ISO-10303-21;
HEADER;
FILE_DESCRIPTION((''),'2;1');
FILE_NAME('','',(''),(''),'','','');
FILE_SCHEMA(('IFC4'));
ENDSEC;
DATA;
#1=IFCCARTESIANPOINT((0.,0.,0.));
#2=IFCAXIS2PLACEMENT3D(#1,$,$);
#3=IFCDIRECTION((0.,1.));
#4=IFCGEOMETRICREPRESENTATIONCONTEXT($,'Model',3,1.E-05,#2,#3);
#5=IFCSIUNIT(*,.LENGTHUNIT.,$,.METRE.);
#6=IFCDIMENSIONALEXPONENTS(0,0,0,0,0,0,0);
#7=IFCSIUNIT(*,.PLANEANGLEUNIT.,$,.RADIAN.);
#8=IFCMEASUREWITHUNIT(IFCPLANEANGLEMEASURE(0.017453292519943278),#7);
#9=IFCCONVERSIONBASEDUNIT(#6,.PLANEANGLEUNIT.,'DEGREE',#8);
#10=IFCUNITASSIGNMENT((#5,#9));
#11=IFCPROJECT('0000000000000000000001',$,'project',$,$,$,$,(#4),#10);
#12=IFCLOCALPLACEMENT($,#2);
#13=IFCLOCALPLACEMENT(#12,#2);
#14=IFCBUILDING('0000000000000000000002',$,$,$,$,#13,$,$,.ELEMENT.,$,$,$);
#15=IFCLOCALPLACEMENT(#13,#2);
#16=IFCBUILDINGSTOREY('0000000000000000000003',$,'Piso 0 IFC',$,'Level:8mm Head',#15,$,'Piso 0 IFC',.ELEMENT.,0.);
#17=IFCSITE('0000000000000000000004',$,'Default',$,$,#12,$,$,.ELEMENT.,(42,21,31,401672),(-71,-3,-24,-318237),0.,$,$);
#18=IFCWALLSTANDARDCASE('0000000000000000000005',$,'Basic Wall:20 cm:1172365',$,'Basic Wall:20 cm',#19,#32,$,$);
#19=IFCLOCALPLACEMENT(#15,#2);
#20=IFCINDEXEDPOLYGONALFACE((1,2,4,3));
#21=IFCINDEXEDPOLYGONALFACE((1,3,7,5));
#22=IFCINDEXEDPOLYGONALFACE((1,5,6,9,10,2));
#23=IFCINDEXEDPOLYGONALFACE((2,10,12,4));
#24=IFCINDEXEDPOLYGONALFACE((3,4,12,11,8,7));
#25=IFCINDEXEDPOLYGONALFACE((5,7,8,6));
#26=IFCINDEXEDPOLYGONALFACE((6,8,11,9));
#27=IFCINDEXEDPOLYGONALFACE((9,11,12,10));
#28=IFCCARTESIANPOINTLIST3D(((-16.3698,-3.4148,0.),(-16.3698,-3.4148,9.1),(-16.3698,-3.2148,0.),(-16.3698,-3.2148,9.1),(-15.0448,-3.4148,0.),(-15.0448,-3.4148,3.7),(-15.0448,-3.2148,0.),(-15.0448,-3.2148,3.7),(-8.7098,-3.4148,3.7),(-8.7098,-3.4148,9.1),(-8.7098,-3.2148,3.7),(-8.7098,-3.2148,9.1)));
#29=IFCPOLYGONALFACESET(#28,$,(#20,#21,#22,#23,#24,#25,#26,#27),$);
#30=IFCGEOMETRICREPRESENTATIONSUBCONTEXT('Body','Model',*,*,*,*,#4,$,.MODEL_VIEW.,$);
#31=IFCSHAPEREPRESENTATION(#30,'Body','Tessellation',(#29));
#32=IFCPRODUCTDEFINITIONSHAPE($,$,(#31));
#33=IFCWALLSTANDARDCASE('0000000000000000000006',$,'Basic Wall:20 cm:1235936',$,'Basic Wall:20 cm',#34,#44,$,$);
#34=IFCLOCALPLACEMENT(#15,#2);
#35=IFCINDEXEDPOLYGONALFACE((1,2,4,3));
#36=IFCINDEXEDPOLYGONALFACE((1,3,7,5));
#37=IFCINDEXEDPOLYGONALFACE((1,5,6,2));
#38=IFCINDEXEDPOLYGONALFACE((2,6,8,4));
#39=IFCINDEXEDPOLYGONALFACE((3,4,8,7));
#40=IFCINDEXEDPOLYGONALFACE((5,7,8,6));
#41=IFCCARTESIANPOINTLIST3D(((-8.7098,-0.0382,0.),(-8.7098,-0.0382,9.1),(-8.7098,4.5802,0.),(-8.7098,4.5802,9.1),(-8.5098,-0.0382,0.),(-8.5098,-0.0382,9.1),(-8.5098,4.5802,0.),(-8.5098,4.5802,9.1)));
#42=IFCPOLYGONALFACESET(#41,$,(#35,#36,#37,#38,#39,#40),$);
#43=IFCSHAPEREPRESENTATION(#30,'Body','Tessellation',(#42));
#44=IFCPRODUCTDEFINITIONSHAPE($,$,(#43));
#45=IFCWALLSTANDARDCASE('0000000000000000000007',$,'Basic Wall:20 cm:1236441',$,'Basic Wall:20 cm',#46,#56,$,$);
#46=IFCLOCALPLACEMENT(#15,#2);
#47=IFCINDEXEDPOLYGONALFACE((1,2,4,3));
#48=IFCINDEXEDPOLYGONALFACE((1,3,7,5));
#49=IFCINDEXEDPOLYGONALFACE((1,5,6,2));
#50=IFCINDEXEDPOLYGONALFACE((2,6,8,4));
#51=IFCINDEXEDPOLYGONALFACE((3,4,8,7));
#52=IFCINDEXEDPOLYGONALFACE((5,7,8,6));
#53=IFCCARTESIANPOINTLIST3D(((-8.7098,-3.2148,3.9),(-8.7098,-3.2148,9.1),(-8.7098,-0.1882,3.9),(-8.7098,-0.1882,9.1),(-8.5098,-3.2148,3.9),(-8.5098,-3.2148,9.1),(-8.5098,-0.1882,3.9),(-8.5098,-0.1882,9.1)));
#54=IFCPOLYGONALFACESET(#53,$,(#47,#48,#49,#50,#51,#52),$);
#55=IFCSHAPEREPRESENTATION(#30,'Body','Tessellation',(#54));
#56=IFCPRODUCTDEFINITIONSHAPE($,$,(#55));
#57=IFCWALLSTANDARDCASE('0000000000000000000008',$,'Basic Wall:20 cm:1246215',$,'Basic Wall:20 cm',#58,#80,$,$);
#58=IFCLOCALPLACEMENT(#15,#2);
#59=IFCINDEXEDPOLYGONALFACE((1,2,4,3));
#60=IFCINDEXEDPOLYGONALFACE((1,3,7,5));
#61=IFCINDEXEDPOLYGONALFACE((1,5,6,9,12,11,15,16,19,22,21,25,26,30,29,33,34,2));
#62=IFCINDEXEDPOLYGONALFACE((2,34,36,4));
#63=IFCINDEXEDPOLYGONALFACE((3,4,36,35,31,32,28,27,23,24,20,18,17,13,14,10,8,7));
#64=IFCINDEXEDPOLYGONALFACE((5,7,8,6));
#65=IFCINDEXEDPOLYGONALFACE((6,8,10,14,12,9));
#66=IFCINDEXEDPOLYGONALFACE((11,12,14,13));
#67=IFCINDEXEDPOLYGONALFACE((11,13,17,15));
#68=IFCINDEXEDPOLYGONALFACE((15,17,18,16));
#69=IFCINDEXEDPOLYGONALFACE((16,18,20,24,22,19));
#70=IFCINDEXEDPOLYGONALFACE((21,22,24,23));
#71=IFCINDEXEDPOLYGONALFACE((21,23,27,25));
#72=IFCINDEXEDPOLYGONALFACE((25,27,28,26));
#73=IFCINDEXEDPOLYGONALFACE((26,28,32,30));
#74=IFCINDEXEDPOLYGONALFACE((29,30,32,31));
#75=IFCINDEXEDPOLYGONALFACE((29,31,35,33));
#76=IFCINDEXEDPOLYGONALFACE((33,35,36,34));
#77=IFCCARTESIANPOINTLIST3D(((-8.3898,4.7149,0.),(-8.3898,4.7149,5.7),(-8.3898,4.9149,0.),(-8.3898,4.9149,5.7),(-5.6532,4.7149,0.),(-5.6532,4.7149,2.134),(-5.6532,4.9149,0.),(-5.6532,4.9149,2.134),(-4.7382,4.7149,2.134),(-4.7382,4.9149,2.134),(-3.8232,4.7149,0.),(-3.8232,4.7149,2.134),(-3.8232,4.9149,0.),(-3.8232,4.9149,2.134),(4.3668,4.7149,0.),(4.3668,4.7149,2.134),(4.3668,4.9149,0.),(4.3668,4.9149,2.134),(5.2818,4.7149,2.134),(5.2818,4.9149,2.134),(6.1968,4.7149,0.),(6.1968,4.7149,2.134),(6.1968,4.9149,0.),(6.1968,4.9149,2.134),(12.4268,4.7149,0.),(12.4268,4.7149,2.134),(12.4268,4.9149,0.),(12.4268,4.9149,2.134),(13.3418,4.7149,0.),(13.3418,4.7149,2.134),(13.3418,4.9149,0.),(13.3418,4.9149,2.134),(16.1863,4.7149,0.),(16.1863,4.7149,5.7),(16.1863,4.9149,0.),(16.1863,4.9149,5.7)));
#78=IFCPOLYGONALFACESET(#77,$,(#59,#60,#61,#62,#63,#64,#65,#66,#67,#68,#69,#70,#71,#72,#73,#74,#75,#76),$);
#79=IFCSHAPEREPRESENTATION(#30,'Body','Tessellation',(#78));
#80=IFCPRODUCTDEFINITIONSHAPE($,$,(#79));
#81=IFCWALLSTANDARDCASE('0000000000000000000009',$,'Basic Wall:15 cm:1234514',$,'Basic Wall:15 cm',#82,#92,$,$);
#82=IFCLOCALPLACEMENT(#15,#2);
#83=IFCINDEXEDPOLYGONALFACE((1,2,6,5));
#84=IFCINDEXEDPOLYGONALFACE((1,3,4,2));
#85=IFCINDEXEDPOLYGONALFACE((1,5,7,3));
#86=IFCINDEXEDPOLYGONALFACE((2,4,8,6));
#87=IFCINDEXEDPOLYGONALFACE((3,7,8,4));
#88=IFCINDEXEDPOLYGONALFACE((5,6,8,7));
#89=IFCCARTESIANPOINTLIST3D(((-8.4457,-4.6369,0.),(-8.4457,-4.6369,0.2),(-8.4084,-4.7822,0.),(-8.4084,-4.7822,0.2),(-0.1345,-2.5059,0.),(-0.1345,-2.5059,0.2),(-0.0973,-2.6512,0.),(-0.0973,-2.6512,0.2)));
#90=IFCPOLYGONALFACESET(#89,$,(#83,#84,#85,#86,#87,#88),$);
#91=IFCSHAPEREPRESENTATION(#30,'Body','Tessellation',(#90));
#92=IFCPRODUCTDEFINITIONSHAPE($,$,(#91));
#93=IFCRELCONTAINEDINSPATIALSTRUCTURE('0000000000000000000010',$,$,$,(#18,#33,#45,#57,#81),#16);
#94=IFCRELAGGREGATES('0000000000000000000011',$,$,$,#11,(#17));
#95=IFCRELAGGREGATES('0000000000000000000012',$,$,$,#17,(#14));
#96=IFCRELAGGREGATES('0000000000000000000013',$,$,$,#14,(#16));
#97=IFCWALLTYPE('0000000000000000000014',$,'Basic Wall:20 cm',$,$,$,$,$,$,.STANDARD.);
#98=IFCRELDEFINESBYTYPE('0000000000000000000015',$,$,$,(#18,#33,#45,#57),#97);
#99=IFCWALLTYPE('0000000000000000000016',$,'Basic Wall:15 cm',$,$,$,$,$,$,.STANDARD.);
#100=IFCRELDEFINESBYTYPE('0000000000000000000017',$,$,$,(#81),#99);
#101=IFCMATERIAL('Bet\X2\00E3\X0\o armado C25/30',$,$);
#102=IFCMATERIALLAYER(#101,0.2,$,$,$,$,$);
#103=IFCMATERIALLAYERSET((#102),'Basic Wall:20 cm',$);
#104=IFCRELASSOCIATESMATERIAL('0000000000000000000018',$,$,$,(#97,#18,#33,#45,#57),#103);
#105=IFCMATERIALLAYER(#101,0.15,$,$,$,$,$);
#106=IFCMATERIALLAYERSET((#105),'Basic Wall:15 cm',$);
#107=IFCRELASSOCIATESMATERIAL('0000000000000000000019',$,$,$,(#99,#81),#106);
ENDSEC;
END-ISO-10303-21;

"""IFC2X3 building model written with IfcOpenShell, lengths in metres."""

from ifc_helpers import new_model, entity, si_unit, converted_unit, direction, frame, frame_2d, origin, origin_2d_with_axis, place, context, subcontext, project, spatial, polyline, rectangle, extrude, clip, bounded_halfspace, material, layer, layer_set, layer_usage, type_object, element, save


model = new_model("IFC2X3")

# Units and contexts
model_context = context("Model", 3, precision=1e-05, world=origin(), true_north=direction((0.0, 1.0)))
body_context = subcontext(model_context, "Body", "Model", "MODEL_VIEW")
ifc_project = project(units=[si_unit("LENGTHUNIT", "METRE"), converted_unit("PLANEANGLEUNIT", "DEGREE", entity("IfcPlaneAngleMeasure", 0.017453292519943278), si_unit("PLANEANGLEUNIT", "RADIAN"), dimensions=[0, 0, 0, 0, 0, 0, 0])], contexts=[model_context])

# Site, building, storey
site_placement = place(None, origin())
site = spatial("IfcSite", under=ifc_project, at=site_placement, Name="Default", CompositionType="ELEMENT", RefLatitude=(42, 21, 31, 401672), RefLongitude=(-71, -3, -24, -318237), RefElevation=0.0)
building_placement = place(site_placement, origin())
building = spatial("IfcBuilding", under=site, at=building_placement, CompositionType="ELEMENT")
storey_placement = place(building_placement, origin())
storey = spatial("IfcBuildingStorey", under=building, at=storey_placement, Name="Piso 0 IFC", ObjectType="Level:8mm Head", LongName="Piso 0 IFC", CompositionType="ELEMENT", Elevation=0.0)

# Wall, opening
ifc_material_1 = material(Name="Betão armado C25/30")
ifc_layer_1 = layer(ifc_material_1, 0.2)
ifc_layer_set_1 = layer_set([ifc_layer_1], Name="Basic Wall:20 cm")
ifc_layer_usage_1 = layer_usage(ifc_layer_set_1, "AXIS2", "NEGATIVE", 0.1)
wall_type_1 = type_object("IfcWallType", Name="Basic Wall:20 cm", PredefinedType="STANDARD", material=ifc_layer_set_1)
wall_1_placement = place(storey_placement, frame((-8.7098, -3.3148, 0.0), z_axis=(0.0, 0.0, 1.0), x_axis=(-1.0, 0.0, 0.0)))
wall_1 = element("IfcWallStandardCase", 1, at=wall_1_placement, inside=storey, type_object=wall_type_1, material=ifc_layer_usage_1, Name="Basic Wall:20 cm:1172365", ObjectType="Basic Wall:20 cm", context=body_context, shape_type="Clipping", body=[
    clip(extrude(rectangle(XDim=7.66, YDim=0.2, at=frame_2d((3.83, 0.0), x_axis=(-1.0, 0.0))), origin(), (0.0, 0.0, 1.0), 9.1), bounded_halfspace(frame((0.0, -0.1, 9.1), z_axis=(0.0, 0.0, -1.0), x_axis=(1.0, 0.0, 0.0)), True, frame((0.0, -0.1, 9.1)), polyline([(0.0, 0.0), (7.66, 0.0), (7.66, 0.2), (7.46, 0.2), (0.0, 0.2), (0.0, 0.0)]))),
])
opening_1_placement = place(wall_1_placement, origin())
element("IfcOpeningElement", 2, at=opening_1_placement, cuts=wall_1, ObjectType="Opening", context=body_context, shape_type="SweptSolid", body=[
    extrude(rectangle(XDim=3.7, YDim=6.435, at=origin_2d_with_axis()), frame((3.1175, 0.1, 1.85), z_axis=(0.0, -1.0, 0.0), x_axis=(0.0, 0.0, 1.0)), (0.0, 0.0, 1.0), 0.2),
])

# Walls
ifc_layer_usage_2 = layer_usage(ifc_layer_set_1, "AXIS2", "NEGATIVE", 0.1)
wall_2_placement = place(storey_placement, frame((-8.6098, -0.0382, 0.0), z_axis=(0.0, 0.0, 1.0), x_axis=(0.0, 1.0, 0.0)))
element("IfcWallStandardCase", 3, at=wall_2_placement, inside=storey, type_object=wall_type_1, material=ifc_layer_usage_2, Name="Basic Wall:20 cm:1235936", ObjectType="Basic Wall:20 cm", context=body_context, shape_type="Clipping", body=[
    clip(extrude(rectangle(XDim=4.6184, YDim=0.2, at=frame_2d((2.3092, 0.0), x_axis=(-1.0, 0.0))), origin(), (0.0, 0.0, 1.0), 9.1), bounded_halfspace(frame((0.0, -0.1, 9.1), z_axis=(0.0, 0.0, -1.0), x_axis=(0.0, 1.0, 0.0)), True, frame((0.0, -0.1, 9.1)), polyline([(0.0, 0.0), (4.6184, 0.0), (4.6184, 0.2), (0.0, 0.2), (0.0, 0.0)]))),
])
ifc_layer_usage_3 = layer_usage(ifc_layer_set_1, "AXIS2", "NEGATIVE", 0.1)
wall_3_placement = place(storey_placement, frame((-8.6098, -0.1882, 3.9), z_axis=(0.0, 0.0, 1.0), x_axis=(0.0, -1.0, 0.0)))
element("IfcWallStandardCase", 4, at=wall_3_placement, inside=storey, type_object=wall_type_1, material=ifc_layer_usage_3, Name="Basic Wall:20 cm:1236441", ObjectType="Basic Wall:20 cm", context=body_context, shape_type="Clipping", body=[
    clip(extrude(rectangle(XDim=3.0266, YDim=0.2, at=frame_2d((1.5133, 0.0), x_axis=(-1.0, 0.0))), origin(), (0.0, 0.0, 1.0), 5.2), bounded_halfspace(frame((0.0, -0.1, 5.2), z_axis=(0.0, 0.0, -1.0), x_axis=(0.0, -1.0, 0.0)), True, frame((0.0, -0.1, 5.2)), polyline([(0.0, 0.0), (3.0266, 0.0), (3.0266, 0.2), (0.0, 0.2), (0.0, 0.0)]))),
])

# Wall, openings
ifc_layer_usage_4 = layer_usage(ifc_layer_set_1, "AXIS2", "NEGATIVE", 0.1)
wall_4_placement = place(storey_placement, frame((-8.3898, 4.8149, 0.0)))
wall_4 = element("IfcWallStandardCase", 5, at=wall_4_placement, inside=storey, type_object=wall_type_1, material=ifc_layer_usage_4, Name="Basic Wall:20 cm:1246215", ObjectType="Basic Wall:20 cm", context=body_context, shape_type="SweptSolid", body=[
    extrude(rectangle(XDim=24.5761, YDim=0.2, at=frame_2d((12.2881, 0.0), x_axis=(-1.0, 0.0))), origin(), (0.0, 0.0, 1.0), 5.7),
])
opening_2_placement = place(wall_4_placement, frame((8.3898, -4.8149, 0.0)))
element("IfcOpeningElement", 6, at=opening_2_placement, cuts=wall_4, ObjectType="Opening", context=body_context, shape_type="SweptSolid", body=[
    extrude(rectangle(XDim=2.134, YDim=0.915, at=frame_2d((0.0, 0.0), x_axis=(0.0, 1.0))), frame((12.8843, 3.1909, 1.067), z_axis=(0.0, 1.0, 0.0), x_axis=(1.0, 0.0, 0.0)), (0.0, 0.0, 1.0), 3.048),
])
opening_3_placement = place(wall_4_placement, frame((8.3898, -4.8149, 0.0)))
element("IfcOpeningElement", 7, at=opening_3_placement, cuts=wall_4, ObjectType="Opening", context=body_context, shape_type="SweptSolid", body=[
    extrude(rectangle(XDim=2.134, YDim=0.915, at=frame_2d((0.0, 0.0), x_axis=(0.0, 1.0))), frame((-5.1957, 3.1909, 1.067), z_axis=(0.0, 1.0, 0.0), x_axis=(1.0, 0.0, 0.0)), (0.0, 0.0, 1.0), 3.048),
])
opening_4_placement = place(wall_4_placement, frame((8.3898, -4.8149, 0.0)))
element("IfcOpeningElement", 8, at=opening_4_placement, cuts=wall_4, ObjectType="Opening", context=body_context, shape_type="SweptSolid", body=[
    extrude(rectangle(XDim=2.134, YDim=0.915, at=frame_2d((0.0, 0.0), x_axis=(0.0, 1.0))), frame((-4.2807, 3.1909, 1.067), z_axis=(0.0, 1.0, 0.0), x_axis=(1.0, 0.0, 0.0)), (0.0, 0.0, 1.0), 3.048),
])
opening_5_placement = place(wall_4_placement, frame((8.3898, -4.8149, 0.0)))
element("IfcOpeningElement", 9, at=opening_5_placement, cuts=wall_4, ObjectType="Opening", context=body_context, shape_type="SweptSolid", body=[
    extrude(rectangle(XDim=2.134, YDim=0.915, at=frame_2d((0.0, 0.0), x_axis=(0.0, 1.0))), frame((5.7393, 3.1909, 1.067), z_axis=(0.0, 1.0, 0.0), x_axis=(1.0, 0.0, 0.0)), (0.0, 0.0, 1.0), 3.048),
])
opening_6_placement = place(wall_4_placement, frame((8.3898, -4.8149, 0.0)))
element("IfcOpeningElement", 10, at=opening_6_placement, cuts=wall_4, ObjectType="Opening", context=body_context, shape_type="SweptSolid", body=[
    extrude(rectangle(XDim=2.134, YDim=0.915, at=frame_2d((0.0, 0.0), x_axis=(0.0, 1.0))), frame((4.8243, 3.1909, 1.067), z_axis=(0.0, 1.0, 0.0), x_axis=(1.0, 0.0, 0.0)), (0.0, 0.0, 1.0), 3.048),
])

# Wall
ifc_layer_2 = layer(ifc_material_1, 0.15)
ifc_layer_set_2 = layer_set([ifc_layer_2], Name="Basic Wall:15 cm")
ifc_layer_usage_5 = layer_usage(ifc_layer_set_2, "AXIS2", "NEGATIVE", 0.075)
wall_type_2 = type_object("IfcWallType", Name="Basic Wall:15 cm", PredefinedType="STANDARD", material=ifc_layer_set_2)
wall_5_placement = place(storey_placement, frame((-8.4271, -4.7095, 0.0), z_axis=(0.0, 0.0, 1.0), x_axis=(0.968666, 0.248367, 0.0)))
element("IfcWallStandardCase", 11, at=wall_5_placement, inside=storey, type_object=wall_type_2, material=ifc_layer_usage_5, Name="Basic Wall:15 cm:1234514", ObjectType="Basic Wall:15 cm", context=body_context, shape_type="SweptSolid", body=[
    extrude(rectangle(XDim=8.58, YDim=0.15, at=frame_2d((4.29, 0.0), x_axis=(-1.0, 0.0))), origin(), (0.0, 0.0, 1.0), 0.2),
])

save(model, "model.ifc")
